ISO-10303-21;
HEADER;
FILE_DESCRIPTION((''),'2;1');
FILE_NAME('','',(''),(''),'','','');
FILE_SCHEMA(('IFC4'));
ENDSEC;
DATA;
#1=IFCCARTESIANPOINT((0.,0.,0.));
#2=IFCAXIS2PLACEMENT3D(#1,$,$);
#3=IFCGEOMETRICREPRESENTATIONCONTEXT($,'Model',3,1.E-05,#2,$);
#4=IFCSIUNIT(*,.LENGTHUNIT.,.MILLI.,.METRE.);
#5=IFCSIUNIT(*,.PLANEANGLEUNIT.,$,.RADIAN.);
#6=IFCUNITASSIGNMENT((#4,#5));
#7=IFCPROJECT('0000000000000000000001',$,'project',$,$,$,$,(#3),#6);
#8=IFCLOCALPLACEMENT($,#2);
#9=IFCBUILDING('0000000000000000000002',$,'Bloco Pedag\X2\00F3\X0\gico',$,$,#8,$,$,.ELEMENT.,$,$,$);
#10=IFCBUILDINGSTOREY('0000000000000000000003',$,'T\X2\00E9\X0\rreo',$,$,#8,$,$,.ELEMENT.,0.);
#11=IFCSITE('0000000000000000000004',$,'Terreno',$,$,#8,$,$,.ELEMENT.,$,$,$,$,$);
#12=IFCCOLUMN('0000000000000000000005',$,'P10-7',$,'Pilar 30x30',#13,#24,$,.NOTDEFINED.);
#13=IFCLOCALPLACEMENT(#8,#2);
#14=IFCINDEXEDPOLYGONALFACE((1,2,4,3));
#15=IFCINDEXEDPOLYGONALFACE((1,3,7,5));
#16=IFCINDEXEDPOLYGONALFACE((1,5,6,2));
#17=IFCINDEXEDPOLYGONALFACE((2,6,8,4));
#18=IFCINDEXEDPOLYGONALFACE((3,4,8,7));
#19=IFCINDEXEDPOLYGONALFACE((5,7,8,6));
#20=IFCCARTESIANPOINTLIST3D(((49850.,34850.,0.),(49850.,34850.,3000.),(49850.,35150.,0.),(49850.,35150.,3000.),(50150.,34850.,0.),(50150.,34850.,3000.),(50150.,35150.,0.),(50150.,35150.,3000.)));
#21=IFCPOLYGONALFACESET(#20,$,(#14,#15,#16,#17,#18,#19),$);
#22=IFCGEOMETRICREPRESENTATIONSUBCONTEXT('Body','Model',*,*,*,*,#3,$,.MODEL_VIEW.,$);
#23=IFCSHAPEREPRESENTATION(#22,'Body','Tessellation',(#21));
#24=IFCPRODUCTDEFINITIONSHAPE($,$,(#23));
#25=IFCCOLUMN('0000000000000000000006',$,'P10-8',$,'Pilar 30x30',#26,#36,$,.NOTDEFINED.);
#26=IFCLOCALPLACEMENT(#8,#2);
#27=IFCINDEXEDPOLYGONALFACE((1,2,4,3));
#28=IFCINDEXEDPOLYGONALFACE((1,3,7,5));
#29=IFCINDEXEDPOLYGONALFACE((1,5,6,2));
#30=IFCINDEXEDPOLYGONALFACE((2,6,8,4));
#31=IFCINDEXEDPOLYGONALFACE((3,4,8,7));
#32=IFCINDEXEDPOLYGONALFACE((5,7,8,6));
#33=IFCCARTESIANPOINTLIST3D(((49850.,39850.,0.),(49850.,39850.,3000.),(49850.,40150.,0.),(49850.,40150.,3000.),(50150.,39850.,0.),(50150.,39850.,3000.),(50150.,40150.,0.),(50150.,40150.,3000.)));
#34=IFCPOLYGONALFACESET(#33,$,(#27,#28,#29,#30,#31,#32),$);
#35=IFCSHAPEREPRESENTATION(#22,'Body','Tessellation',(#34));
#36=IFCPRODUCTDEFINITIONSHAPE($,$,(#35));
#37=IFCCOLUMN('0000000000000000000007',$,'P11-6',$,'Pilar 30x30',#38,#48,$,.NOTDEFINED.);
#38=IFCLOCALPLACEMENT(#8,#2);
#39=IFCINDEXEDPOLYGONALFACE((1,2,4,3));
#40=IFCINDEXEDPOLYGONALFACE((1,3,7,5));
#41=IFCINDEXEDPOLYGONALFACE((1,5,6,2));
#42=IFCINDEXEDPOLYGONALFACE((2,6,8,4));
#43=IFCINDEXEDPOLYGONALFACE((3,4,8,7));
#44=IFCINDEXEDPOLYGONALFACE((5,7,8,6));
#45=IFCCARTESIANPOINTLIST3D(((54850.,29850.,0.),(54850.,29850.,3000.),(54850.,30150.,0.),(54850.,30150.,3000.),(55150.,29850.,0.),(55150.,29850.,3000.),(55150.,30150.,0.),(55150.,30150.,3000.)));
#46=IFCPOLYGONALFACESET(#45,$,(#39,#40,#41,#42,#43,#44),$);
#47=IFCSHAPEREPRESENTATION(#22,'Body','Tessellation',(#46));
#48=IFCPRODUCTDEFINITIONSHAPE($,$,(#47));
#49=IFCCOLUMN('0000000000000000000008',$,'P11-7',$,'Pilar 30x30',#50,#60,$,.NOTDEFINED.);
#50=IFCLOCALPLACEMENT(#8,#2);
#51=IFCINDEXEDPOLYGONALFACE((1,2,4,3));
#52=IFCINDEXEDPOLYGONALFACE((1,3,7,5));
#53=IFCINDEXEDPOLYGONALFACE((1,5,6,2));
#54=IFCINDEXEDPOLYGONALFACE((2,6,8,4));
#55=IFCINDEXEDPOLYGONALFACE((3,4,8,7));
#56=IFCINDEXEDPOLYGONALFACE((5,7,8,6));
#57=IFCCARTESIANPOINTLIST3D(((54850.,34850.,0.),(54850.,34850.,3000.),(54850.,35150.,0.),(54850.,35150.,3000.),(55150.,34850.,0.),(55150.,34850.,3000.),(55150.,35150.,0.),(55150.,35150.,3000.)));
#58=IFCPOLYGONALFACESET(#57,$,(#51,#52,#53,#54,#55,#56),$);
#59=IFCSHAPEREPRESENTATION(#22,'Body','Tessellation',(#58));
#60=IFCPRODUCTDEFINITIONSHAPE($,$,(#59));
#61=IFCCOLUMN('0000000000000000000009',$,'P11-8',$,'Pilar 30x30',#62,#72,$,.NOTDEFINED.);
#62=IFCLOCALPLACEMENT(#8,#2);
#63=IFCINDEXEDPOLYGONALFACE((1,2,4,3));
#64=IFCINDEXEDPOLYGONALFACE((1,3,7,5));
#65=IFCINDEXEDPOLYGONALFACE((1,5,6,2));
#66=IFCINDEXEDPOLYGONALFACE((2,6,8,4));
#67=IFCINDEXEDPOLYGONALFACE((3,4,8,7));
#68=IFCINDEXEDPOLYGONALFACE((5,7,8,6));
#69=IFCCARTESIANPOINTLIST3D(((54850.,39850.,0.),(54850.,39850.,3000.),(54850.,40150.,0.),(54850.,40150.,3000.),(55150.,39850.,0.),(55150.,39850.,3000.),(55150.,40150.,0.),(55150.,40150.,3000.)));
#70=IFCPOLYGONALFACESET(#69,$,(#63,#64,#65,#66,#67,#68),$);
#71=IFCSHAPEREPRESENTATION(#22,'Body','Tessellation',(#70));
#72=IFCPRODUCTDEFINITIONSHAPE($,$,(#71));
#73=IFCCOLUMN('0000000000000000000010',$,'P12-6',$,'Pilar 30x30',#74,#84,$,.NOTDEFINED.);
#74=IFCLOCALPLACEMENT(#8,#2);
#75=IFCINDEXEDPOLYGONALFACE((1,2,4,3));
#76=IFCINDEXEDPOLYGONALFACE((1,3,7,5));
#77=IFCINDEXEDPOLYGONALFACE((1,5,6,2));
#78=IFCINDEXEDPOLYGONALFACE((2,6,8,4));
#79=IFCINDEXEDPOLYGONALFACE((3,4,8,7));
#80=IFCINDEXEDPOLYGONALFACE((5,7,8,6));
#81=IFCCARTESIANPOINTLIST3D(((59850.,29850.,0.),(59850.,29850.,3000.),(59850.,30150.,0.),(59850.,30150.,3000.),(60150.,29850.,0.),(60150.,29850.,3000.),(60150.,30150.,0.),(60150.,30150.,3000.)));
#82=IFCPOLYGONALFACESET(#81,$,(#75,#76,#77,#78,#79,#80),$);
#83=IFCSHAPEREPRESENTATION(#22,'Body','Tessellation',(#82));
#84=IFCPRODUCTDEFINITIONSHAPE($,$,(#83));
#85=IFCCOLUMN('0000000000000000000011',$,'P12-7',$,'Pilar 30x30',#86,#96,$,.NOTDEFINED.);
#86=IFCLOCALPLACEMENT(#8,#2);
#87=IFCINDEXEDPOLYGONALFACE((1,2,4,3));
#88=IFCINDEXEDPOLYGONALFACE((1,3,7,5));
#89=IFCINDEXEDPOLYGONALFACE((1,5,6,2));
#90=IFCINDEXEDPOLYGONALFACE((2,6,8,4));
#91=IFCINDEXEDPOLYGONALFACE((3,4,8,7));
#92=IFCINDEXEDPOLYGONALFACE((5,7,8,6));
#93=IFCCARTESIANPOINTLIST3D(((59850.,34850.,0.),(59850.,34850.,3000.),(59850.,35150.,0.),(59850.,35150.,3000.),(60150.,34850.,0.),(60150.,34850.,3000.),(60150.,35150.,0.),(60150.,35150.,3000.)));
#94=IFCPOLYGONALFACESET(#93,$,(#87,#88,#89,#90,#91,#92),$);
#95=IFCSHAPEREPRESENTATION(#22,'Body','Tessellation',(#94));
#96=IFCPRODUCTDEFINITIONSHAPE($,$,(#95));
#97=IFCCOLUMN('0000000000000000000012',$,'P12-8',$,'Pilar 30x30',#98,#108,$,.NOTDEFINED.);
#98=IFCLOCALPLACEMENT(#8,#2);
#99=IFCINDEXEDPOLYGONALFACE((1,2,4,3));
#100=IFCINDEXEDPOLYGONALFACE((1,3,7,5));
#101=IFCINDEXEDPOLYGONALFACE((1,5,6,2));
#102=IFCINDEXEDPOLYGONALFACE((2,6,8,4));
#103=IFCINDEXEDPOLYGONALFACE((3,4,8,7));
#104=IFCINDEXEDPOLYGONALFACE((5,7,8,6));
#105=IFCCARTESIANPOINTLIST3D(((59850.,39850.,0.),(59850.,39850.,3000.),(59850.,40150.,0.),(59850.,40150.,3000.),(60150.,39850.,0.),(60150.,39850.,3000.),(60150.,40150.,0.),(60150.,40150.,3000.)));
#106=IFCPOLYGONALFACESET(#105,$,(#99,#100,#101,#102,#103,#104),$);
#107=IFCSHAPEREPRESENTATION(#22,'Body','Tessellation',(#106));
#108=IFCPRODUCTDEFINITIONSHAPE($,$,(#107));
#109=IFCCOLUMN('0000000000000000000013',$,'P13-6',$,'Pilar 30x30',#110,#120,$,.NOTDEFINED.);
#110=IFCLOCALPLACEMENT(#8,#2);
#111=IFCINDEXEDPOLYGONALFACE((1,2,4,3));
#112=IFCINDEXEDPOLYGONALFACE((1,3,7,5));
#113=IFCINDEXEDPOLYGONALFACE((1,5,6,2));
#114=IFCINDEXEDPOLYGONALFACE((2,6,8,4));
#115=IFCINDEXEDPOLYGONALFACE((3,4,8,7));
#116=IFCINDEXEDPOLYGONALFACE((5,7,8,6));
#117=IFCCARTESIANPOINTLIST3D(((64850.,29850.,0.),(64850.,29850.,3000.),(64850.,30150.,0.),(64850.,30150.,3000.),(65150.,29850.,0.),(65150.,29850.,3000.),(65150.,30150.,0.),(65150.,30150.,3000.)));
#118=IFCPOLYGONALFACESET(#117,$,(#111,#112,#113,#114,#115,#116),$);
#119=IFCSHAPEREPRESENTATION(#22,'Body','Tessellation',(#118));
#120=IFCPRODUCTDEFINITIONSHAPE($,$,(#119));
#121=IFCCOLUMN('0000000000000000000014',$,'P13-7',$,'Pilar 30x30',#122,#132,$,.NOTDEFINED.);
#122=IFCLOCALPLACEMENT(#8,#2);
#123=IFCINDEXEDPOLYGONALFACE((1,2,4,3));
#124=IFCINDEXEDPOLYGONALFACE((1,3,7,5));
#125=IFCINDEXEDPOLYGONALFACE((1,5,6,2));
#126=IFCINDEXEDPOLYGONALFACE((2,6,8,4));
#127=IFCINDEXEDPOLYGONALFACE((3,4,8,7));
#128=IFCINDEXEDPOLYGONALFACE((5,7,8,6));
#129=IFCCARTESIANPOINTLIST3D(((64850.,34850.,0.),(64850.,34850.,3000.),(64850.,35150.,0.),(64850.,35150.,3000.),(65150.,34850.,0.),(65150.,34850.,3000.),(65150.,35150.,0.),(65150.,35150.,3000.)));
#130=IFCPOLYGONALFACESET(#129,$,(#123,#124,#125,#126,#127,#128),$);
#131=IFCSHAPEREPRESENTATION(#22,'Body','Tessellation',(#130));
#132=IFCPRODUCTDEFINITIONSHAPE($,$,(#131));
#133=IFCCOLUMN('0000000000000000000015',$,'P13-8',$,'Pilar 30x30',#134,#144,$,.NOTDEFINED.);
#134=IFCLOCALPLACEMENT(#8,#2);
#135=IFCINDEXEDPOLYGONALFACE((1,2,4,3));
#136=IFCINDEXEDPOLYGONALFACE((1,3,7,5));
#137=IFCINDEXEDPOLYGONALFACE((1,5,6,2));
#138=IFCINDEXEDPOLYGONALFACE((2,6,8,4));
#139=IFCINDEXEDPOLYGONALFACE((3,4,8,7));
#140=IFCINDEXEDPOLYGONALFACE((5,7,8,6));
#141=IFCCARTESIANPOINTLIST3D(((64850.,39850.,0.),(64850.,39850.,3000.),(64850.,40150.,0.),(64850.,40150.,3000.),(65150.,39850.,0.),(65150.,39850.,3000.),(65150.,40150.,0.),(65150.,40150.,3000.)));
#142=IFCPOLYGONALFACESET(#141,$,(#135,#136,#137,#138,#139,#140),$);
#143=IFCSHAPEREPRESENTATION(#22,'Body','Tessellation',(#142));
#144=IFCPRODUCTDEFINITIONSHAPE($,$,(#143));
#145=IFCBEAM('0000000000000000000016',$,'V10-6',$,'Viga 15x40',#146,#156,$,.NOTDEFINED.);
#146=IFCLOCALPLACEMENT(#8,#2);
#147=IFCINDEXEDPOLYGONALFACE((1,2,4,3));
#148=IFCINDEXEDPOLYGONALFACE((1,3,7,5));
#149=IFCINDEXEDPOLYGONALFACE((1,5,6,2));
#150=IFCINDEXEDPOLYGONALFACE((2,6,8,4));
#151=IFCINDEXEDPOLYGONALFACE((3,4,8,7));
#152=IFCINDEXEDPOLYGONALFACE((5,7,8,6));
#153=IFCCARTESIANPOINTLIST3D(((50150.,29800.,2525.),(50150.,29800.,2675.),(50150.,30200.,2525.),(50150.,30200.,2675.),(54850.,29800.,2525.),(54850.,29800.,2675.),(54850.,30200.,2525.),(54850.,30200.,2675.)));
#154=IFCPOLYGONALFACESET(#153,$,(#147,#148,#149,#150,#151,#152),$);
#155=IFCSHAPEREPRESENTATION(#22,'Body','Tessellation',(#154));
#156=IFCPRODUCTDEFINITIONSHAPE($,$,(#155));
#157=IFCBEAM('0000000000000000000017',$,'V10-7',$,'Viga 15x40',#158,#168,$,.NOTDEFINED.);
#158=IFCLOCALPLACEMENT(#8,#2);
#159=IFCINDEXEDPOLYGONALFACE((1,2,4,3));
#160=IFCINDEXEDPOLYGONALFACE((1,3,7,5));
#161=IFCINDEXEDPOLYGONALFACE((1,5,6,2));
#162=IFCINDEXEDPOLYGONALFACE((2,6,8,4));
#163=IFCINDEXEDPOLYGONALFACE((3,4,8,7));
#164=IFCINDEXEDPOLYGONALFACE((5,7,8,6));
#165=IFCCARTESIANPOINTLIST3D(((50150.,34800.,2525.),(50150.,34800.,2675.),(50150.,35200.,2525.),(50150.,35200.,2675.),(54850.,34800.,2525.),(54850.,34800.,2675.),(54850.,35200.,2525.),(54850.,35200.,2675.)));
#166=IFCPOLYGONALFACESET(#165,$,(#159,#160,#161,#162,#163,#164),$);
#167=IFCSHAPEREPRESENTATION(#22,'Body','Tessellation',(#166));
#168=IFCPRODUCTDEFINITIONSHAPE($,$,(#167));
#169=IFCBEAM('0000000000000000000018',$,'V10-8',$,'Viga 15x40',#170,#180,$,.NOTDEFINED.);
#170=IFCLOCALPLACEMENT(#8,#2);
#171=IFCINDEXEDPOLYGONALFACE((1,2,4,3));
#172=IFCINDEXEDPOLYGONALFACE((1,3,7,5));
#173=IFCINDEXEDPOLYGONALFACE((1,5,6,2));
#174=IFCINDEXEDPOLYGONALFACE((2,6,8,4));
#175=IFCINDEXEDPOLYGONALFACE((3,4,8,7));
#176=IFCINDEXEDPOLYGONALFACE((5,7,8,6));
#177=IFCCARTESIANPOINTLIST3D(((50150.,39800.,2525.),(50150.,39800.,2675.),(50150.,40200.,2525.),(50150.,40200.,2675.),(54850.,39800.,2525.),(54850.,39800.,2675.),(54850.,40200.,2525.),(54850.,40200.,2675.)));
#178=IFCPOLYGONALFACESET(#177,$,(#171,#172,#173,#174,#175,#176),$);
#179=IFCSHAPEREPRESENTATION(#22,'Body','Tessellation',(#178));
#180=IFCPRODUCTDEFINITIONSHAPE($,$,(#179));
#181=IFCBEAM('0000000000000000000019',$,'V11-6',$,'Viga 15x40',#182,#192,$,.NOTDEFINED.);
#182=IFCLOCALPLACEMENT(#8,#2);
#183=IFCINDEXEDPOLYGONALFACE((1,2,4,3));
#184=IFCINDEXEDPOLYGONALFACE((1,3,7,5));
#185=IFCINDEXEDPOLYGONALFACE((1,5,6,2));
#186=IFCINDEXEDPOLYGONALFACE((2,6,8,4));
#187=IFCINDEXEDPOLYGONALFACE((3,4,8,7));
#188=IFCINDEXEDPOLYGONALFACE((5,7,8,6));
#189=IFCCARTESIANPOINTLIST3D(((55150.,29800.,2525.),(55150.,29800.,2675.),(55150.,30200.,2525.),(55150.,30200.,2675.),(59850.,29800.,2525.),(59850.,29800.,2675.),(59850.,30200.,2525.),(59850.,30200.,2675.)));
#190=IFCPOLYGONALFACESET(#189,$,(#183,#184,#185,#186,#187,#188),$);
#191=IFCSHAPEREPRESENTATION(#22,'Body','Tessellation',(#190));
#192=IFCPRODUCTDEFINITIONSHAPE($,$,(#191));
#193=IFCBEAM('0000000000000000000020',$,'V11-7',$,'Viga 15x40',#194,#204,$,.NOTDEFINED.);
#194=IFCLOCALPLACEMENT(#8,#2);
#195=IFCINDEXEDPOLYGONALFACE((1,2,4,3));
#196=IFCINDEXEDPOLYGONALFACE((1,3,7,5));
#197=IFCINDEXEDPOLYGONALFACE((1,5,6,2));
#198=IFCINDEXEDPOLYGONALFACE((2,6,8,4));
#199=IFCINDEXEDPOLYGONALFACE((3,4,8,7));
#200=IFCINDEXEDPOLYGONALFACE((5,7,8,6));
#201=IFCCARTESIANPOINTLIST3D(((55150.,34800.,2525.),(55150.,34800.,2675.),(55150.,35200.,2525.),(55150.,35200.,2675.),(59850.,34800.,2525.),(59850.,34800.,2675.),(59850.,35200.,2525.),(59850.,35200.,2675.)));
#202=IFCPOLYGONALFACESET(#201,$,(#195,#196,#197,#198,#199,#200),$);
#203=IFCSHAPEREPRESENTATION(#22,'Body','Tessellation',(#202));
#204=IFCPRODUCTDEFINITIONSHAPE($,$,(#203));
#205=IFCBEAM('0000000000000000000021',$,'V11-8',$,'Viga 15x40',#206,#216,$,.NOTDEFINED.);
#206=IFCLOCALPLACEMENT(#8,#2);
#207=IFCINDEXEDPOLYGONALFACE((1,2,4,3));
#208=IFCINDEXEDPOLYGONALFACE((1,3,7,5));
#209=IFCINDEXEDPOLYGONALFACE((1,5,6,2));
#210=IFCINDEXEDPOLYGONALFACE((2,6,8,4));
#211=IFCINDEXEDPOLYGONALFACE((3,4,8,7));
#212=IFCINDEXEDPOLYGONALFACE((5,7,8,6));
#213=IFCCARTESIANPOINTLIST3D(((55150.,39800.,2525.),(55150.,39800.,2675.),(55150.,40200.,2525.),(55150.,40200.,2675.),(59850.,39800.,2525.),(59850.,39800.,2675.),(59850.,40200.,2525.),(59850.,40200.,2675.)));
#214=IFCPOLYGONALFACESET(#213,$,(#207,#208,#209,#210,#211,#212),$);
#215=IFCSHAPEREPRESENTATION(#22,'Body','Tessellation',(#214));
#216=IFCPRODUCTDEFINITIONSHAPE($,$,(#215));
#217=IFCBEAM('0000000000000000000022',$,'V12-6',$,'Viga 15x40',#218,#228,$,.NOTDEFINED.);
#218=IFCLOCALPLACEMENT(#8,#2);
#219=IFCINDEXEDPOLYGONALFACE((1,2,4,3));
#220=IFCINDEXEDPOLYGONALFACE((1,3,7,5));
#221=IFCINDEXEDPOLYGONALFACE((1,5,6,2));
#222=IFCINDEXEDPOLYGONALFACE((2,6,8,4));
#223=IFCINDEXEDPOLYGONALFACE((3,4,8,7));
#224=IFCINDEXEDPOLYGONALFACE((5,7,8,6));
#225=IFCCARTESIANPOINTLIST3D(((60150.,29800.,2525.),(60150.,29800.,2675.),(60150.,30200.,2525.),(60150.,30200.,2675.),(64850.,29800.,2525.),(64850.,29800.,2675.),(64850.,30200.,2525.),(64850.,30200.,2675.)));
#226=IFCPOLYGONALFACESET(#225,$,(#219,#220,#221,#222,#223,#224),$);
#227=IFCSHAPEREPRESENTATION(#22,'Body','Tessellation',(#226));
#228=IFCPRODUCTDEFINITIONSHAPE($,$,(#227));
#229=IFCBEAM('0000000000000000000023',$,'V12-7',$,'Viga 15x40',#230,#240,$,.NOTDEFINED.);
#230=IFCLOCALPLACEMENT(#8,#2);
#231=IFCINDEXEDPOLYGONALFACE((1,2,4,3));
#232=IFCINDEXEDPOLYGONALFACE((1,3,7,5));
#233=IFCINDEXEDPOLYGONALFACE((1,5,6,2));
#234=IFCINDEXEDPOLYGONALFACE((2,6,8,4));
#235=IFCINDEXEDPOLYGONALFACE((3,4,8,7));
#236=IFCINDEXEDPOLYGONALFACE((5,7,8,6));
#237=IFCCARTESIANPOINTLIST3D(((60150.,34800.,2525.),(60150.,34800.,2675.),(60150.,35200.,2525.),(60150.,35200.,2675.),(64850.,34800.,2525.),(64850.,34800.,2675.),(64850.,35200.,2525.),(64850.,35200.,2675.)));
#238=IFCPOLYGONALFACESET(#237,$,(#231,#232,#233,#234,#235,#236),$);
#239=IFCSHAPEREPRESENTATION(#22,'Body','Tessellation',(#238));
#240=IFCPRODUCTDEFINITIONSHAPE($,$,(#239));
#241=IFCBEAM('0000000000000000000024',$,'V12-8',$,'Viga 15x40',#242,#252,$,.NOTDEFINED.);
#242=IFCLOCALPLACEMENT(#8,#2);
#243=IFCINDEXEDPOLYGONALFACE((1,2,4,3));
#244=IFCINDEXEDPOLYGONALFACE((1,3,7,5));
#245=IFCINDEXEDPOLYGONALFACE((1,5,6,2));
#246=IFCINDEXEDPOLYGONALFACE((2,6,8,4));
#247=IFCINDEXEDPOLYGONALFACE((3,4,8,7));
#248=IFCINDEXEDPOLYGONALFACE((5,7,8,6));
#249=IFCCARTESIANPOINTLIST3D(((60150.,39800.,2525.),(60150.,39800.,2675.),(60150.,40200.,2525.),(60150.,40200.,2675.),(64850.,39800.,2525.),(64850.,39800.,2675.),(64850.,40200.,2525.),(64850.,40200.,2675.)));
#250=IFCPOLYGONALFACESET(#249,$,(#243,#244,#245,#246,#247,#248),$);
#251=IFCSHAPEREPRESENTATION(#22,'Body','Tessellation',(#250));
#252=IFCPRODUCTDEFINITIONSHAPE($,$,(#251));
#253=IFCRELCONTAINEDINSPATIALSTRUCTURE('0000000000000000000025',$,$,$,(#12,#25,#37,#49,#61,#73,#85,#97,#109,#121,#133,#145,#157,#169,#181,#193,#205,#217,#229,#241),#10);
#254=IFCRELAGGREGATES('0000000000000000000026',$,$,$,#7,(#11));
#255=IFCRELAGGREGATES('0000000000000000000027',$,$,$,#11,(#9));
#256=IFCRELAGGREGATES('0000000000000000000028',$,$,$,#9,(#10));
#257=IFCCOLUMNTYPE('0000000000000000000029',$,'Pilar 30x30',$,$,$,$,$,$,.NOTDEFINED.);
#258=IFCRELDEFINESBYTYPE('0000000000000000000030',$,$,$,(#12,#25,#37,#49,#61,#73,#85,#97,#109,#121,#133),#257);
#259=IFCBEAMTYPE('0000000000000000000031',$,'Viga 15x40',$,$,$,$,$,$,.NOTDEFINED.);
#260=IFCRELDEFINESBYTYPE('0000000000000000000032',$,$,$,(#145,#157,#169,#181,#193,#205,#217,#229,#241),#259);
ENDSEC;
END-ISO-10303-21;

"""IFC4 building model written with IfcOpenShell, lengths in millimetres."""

from ifc_helpers import new_model, si_unit, frame, origin, origin_2d, place, context, subcontext, project, spatial, rectangle, extrude, type_object, element, save


model = new_model("IFC4")

# Units and contexts
model_context = context("Model", 3, precision=1e-05, world=origin())
body_context = subcontext(model_context, "Body", "Model", "MODEL_VIEW")
ifc_project = project(units=[si_unit("LENGTHUNIT", "METRE", prefix="MILLI"), si_unit("PLANEANGLEUNIT", "RADIAN")], contexts=[model_context])

# Site, building, storey
placement = place(None, origin())
site = spatial("IfcSite", under=ifc_project, at=placement, Name="Terreno", CompositionType="ELEMENT")
building = spatial("IfcBuilding", under=site, at=placement, Name="Bloco Pedagógico", CompositionType="ELEMENT")
storey = spatial("IfcBuildingStorey", under=building, at=placement, Name="Térreo", CompositionType="ELEMENT", Elevation=0.0)

# Columns
column_type = type_object("IfcColumnType", Name="Pilar 30x30", PredefinedType="NOTDEFINED")
for number, where, z_axis, x_axis, name in (
    (1, (50000.0, 35000.0, 0.0), (0.0, 0.0, 1.0), (1.0, 0.0, 0.0), "P10-7"),
    (2, (50000.0, 40000.0, 0.0), (0.0, 0.0, 1.0), (1.0, 0.0, 0.0), "P10-8"),
    (3, (55000.0, 30000.0, 0.0), (0.0, 0.0, 1.0), (1.0, 0.0, 0.0), "P11-6"),
    (4, (55000.0, 35000.0, 0.0), (0.0, 0.0, 1.0), (1.0, 0.0, 0.0), "P11-7"),
    (5, (55000.0, 40000.0, 0.0), (0.0, 0.0, 1.0), (1.0, 0.0, 0.0), "P11-8"),
    (6, (60000.0, 30000.0, 0.0), (0.0, 0.0, 1.0), (1.0, 0.0, 0.0), "P12-6"),
    (7, (60000.0, 35000.0, 0.0), (0.0, 0.0, 1.0), (1.0, 0.0, 0.0), "P12-7"),
    (8, (60000.0, 40000.0, 0.0), (0.0, 0.0, 1.0), (1.0, 0.0, 0.0), "P12-8"),
    (9, (65000.0, 30000.0, 0.0), (0.0, 0.0, 1.0), (1.0, 0.0, 0.0), "P13-6"),
    (10, (65000.0, 35000.0, 0.0), (0.0, 0.0, 1.0), (1.0, 0.0, 0.0), "P13-7"),
    (11, (65000.0, 40000.0, 0.0), (0.0, 0.0, 1.0), (1.0, 0.0, 0.0), "P13-8"),
):
    element("IfcColumn", number, at=place(None, frame(where, z_axis=z_axis, x_axis=x_axis)), inside=storey, type_object=column_type, Name=name, ObjectType="Pilar 30x30", PredefinedType="NOTDEFINED", context=body_context, shape_type="SweptSolid", body=[
        extrude(rectangle(XDim=300.0, YDim=300.0, at=origin_2d()), None, (0.0, 0.0, 1.0), 3000.0),
    ])

# Beams
beam_type = type_object("IfcBeamType", Name="Viga 15x40", PredefinedType="NOTDEFINED")
for number, where, z_axis, x_axis, name in (
    (12, (50150.0, 30000.0, 2600.0), (1.0, 0.0, 0.0), (0.0, 1.0, 0.0), "V10-6"),
    (13, (50150.0, 35000.0, 2600.0), (1.0, 0.0, 0.0), (0.0, 1.0, 0.0), "V10-7"),
    (14, (50150.0, 40000.0, 2600.0), (1.0, 0.0, 0.0), (0.0, 1.0, 0.0), "V10-8"),
    (15, (55150.0, 30000.0, 2600.0), (1.0, 0.0, 0.0), (0.0, 1.0, 0.0), "V11-6"),
    (16, (55150.0, 35000.0, 2600.0), (1.0, 0.0, 0.0), (0.0, 1.0, 0.0), "V11-7"),
    (17, (55150.0, 40000.0, 2600.0), (1.0, 0.0, 0.0), (0.0, 1.0, 0.0), "V11-8"),
    (18, (60150.0, 30000.0, 2600.0), (1.0, 0.0, 0.0), (0.0, 1.0, 0.0), "V12-6"),
    (19, (60150.0, 35000.0, 2600.0), (1.0, 0.0, 0.0), (0.0, 1.0, 0.0), "V12-7"),
    (20, (60150.0, 40000.0, 2600.0), (1.0, 0.0, 0.0), (0.0, 1.0, 0.0), "V12-8"),
):
    element("IfcBeam", number, at=place(None, frame(where, z_axis=z_axis, x_axis=x_axis)), inside=storey, type_object=beam_type, Name=name, ObjectType="Viga 15x40", PredefinedType="NOTDEFINED", context=body_context, shape_type="SweptSolid", body=[
        extrude(rectangle(XDim=400.0, YDim=150.0, at=origin_2d()), None, (0.0, 0.0, 1.0), 4700.0),
    ])

save(model, "model.ifc")
